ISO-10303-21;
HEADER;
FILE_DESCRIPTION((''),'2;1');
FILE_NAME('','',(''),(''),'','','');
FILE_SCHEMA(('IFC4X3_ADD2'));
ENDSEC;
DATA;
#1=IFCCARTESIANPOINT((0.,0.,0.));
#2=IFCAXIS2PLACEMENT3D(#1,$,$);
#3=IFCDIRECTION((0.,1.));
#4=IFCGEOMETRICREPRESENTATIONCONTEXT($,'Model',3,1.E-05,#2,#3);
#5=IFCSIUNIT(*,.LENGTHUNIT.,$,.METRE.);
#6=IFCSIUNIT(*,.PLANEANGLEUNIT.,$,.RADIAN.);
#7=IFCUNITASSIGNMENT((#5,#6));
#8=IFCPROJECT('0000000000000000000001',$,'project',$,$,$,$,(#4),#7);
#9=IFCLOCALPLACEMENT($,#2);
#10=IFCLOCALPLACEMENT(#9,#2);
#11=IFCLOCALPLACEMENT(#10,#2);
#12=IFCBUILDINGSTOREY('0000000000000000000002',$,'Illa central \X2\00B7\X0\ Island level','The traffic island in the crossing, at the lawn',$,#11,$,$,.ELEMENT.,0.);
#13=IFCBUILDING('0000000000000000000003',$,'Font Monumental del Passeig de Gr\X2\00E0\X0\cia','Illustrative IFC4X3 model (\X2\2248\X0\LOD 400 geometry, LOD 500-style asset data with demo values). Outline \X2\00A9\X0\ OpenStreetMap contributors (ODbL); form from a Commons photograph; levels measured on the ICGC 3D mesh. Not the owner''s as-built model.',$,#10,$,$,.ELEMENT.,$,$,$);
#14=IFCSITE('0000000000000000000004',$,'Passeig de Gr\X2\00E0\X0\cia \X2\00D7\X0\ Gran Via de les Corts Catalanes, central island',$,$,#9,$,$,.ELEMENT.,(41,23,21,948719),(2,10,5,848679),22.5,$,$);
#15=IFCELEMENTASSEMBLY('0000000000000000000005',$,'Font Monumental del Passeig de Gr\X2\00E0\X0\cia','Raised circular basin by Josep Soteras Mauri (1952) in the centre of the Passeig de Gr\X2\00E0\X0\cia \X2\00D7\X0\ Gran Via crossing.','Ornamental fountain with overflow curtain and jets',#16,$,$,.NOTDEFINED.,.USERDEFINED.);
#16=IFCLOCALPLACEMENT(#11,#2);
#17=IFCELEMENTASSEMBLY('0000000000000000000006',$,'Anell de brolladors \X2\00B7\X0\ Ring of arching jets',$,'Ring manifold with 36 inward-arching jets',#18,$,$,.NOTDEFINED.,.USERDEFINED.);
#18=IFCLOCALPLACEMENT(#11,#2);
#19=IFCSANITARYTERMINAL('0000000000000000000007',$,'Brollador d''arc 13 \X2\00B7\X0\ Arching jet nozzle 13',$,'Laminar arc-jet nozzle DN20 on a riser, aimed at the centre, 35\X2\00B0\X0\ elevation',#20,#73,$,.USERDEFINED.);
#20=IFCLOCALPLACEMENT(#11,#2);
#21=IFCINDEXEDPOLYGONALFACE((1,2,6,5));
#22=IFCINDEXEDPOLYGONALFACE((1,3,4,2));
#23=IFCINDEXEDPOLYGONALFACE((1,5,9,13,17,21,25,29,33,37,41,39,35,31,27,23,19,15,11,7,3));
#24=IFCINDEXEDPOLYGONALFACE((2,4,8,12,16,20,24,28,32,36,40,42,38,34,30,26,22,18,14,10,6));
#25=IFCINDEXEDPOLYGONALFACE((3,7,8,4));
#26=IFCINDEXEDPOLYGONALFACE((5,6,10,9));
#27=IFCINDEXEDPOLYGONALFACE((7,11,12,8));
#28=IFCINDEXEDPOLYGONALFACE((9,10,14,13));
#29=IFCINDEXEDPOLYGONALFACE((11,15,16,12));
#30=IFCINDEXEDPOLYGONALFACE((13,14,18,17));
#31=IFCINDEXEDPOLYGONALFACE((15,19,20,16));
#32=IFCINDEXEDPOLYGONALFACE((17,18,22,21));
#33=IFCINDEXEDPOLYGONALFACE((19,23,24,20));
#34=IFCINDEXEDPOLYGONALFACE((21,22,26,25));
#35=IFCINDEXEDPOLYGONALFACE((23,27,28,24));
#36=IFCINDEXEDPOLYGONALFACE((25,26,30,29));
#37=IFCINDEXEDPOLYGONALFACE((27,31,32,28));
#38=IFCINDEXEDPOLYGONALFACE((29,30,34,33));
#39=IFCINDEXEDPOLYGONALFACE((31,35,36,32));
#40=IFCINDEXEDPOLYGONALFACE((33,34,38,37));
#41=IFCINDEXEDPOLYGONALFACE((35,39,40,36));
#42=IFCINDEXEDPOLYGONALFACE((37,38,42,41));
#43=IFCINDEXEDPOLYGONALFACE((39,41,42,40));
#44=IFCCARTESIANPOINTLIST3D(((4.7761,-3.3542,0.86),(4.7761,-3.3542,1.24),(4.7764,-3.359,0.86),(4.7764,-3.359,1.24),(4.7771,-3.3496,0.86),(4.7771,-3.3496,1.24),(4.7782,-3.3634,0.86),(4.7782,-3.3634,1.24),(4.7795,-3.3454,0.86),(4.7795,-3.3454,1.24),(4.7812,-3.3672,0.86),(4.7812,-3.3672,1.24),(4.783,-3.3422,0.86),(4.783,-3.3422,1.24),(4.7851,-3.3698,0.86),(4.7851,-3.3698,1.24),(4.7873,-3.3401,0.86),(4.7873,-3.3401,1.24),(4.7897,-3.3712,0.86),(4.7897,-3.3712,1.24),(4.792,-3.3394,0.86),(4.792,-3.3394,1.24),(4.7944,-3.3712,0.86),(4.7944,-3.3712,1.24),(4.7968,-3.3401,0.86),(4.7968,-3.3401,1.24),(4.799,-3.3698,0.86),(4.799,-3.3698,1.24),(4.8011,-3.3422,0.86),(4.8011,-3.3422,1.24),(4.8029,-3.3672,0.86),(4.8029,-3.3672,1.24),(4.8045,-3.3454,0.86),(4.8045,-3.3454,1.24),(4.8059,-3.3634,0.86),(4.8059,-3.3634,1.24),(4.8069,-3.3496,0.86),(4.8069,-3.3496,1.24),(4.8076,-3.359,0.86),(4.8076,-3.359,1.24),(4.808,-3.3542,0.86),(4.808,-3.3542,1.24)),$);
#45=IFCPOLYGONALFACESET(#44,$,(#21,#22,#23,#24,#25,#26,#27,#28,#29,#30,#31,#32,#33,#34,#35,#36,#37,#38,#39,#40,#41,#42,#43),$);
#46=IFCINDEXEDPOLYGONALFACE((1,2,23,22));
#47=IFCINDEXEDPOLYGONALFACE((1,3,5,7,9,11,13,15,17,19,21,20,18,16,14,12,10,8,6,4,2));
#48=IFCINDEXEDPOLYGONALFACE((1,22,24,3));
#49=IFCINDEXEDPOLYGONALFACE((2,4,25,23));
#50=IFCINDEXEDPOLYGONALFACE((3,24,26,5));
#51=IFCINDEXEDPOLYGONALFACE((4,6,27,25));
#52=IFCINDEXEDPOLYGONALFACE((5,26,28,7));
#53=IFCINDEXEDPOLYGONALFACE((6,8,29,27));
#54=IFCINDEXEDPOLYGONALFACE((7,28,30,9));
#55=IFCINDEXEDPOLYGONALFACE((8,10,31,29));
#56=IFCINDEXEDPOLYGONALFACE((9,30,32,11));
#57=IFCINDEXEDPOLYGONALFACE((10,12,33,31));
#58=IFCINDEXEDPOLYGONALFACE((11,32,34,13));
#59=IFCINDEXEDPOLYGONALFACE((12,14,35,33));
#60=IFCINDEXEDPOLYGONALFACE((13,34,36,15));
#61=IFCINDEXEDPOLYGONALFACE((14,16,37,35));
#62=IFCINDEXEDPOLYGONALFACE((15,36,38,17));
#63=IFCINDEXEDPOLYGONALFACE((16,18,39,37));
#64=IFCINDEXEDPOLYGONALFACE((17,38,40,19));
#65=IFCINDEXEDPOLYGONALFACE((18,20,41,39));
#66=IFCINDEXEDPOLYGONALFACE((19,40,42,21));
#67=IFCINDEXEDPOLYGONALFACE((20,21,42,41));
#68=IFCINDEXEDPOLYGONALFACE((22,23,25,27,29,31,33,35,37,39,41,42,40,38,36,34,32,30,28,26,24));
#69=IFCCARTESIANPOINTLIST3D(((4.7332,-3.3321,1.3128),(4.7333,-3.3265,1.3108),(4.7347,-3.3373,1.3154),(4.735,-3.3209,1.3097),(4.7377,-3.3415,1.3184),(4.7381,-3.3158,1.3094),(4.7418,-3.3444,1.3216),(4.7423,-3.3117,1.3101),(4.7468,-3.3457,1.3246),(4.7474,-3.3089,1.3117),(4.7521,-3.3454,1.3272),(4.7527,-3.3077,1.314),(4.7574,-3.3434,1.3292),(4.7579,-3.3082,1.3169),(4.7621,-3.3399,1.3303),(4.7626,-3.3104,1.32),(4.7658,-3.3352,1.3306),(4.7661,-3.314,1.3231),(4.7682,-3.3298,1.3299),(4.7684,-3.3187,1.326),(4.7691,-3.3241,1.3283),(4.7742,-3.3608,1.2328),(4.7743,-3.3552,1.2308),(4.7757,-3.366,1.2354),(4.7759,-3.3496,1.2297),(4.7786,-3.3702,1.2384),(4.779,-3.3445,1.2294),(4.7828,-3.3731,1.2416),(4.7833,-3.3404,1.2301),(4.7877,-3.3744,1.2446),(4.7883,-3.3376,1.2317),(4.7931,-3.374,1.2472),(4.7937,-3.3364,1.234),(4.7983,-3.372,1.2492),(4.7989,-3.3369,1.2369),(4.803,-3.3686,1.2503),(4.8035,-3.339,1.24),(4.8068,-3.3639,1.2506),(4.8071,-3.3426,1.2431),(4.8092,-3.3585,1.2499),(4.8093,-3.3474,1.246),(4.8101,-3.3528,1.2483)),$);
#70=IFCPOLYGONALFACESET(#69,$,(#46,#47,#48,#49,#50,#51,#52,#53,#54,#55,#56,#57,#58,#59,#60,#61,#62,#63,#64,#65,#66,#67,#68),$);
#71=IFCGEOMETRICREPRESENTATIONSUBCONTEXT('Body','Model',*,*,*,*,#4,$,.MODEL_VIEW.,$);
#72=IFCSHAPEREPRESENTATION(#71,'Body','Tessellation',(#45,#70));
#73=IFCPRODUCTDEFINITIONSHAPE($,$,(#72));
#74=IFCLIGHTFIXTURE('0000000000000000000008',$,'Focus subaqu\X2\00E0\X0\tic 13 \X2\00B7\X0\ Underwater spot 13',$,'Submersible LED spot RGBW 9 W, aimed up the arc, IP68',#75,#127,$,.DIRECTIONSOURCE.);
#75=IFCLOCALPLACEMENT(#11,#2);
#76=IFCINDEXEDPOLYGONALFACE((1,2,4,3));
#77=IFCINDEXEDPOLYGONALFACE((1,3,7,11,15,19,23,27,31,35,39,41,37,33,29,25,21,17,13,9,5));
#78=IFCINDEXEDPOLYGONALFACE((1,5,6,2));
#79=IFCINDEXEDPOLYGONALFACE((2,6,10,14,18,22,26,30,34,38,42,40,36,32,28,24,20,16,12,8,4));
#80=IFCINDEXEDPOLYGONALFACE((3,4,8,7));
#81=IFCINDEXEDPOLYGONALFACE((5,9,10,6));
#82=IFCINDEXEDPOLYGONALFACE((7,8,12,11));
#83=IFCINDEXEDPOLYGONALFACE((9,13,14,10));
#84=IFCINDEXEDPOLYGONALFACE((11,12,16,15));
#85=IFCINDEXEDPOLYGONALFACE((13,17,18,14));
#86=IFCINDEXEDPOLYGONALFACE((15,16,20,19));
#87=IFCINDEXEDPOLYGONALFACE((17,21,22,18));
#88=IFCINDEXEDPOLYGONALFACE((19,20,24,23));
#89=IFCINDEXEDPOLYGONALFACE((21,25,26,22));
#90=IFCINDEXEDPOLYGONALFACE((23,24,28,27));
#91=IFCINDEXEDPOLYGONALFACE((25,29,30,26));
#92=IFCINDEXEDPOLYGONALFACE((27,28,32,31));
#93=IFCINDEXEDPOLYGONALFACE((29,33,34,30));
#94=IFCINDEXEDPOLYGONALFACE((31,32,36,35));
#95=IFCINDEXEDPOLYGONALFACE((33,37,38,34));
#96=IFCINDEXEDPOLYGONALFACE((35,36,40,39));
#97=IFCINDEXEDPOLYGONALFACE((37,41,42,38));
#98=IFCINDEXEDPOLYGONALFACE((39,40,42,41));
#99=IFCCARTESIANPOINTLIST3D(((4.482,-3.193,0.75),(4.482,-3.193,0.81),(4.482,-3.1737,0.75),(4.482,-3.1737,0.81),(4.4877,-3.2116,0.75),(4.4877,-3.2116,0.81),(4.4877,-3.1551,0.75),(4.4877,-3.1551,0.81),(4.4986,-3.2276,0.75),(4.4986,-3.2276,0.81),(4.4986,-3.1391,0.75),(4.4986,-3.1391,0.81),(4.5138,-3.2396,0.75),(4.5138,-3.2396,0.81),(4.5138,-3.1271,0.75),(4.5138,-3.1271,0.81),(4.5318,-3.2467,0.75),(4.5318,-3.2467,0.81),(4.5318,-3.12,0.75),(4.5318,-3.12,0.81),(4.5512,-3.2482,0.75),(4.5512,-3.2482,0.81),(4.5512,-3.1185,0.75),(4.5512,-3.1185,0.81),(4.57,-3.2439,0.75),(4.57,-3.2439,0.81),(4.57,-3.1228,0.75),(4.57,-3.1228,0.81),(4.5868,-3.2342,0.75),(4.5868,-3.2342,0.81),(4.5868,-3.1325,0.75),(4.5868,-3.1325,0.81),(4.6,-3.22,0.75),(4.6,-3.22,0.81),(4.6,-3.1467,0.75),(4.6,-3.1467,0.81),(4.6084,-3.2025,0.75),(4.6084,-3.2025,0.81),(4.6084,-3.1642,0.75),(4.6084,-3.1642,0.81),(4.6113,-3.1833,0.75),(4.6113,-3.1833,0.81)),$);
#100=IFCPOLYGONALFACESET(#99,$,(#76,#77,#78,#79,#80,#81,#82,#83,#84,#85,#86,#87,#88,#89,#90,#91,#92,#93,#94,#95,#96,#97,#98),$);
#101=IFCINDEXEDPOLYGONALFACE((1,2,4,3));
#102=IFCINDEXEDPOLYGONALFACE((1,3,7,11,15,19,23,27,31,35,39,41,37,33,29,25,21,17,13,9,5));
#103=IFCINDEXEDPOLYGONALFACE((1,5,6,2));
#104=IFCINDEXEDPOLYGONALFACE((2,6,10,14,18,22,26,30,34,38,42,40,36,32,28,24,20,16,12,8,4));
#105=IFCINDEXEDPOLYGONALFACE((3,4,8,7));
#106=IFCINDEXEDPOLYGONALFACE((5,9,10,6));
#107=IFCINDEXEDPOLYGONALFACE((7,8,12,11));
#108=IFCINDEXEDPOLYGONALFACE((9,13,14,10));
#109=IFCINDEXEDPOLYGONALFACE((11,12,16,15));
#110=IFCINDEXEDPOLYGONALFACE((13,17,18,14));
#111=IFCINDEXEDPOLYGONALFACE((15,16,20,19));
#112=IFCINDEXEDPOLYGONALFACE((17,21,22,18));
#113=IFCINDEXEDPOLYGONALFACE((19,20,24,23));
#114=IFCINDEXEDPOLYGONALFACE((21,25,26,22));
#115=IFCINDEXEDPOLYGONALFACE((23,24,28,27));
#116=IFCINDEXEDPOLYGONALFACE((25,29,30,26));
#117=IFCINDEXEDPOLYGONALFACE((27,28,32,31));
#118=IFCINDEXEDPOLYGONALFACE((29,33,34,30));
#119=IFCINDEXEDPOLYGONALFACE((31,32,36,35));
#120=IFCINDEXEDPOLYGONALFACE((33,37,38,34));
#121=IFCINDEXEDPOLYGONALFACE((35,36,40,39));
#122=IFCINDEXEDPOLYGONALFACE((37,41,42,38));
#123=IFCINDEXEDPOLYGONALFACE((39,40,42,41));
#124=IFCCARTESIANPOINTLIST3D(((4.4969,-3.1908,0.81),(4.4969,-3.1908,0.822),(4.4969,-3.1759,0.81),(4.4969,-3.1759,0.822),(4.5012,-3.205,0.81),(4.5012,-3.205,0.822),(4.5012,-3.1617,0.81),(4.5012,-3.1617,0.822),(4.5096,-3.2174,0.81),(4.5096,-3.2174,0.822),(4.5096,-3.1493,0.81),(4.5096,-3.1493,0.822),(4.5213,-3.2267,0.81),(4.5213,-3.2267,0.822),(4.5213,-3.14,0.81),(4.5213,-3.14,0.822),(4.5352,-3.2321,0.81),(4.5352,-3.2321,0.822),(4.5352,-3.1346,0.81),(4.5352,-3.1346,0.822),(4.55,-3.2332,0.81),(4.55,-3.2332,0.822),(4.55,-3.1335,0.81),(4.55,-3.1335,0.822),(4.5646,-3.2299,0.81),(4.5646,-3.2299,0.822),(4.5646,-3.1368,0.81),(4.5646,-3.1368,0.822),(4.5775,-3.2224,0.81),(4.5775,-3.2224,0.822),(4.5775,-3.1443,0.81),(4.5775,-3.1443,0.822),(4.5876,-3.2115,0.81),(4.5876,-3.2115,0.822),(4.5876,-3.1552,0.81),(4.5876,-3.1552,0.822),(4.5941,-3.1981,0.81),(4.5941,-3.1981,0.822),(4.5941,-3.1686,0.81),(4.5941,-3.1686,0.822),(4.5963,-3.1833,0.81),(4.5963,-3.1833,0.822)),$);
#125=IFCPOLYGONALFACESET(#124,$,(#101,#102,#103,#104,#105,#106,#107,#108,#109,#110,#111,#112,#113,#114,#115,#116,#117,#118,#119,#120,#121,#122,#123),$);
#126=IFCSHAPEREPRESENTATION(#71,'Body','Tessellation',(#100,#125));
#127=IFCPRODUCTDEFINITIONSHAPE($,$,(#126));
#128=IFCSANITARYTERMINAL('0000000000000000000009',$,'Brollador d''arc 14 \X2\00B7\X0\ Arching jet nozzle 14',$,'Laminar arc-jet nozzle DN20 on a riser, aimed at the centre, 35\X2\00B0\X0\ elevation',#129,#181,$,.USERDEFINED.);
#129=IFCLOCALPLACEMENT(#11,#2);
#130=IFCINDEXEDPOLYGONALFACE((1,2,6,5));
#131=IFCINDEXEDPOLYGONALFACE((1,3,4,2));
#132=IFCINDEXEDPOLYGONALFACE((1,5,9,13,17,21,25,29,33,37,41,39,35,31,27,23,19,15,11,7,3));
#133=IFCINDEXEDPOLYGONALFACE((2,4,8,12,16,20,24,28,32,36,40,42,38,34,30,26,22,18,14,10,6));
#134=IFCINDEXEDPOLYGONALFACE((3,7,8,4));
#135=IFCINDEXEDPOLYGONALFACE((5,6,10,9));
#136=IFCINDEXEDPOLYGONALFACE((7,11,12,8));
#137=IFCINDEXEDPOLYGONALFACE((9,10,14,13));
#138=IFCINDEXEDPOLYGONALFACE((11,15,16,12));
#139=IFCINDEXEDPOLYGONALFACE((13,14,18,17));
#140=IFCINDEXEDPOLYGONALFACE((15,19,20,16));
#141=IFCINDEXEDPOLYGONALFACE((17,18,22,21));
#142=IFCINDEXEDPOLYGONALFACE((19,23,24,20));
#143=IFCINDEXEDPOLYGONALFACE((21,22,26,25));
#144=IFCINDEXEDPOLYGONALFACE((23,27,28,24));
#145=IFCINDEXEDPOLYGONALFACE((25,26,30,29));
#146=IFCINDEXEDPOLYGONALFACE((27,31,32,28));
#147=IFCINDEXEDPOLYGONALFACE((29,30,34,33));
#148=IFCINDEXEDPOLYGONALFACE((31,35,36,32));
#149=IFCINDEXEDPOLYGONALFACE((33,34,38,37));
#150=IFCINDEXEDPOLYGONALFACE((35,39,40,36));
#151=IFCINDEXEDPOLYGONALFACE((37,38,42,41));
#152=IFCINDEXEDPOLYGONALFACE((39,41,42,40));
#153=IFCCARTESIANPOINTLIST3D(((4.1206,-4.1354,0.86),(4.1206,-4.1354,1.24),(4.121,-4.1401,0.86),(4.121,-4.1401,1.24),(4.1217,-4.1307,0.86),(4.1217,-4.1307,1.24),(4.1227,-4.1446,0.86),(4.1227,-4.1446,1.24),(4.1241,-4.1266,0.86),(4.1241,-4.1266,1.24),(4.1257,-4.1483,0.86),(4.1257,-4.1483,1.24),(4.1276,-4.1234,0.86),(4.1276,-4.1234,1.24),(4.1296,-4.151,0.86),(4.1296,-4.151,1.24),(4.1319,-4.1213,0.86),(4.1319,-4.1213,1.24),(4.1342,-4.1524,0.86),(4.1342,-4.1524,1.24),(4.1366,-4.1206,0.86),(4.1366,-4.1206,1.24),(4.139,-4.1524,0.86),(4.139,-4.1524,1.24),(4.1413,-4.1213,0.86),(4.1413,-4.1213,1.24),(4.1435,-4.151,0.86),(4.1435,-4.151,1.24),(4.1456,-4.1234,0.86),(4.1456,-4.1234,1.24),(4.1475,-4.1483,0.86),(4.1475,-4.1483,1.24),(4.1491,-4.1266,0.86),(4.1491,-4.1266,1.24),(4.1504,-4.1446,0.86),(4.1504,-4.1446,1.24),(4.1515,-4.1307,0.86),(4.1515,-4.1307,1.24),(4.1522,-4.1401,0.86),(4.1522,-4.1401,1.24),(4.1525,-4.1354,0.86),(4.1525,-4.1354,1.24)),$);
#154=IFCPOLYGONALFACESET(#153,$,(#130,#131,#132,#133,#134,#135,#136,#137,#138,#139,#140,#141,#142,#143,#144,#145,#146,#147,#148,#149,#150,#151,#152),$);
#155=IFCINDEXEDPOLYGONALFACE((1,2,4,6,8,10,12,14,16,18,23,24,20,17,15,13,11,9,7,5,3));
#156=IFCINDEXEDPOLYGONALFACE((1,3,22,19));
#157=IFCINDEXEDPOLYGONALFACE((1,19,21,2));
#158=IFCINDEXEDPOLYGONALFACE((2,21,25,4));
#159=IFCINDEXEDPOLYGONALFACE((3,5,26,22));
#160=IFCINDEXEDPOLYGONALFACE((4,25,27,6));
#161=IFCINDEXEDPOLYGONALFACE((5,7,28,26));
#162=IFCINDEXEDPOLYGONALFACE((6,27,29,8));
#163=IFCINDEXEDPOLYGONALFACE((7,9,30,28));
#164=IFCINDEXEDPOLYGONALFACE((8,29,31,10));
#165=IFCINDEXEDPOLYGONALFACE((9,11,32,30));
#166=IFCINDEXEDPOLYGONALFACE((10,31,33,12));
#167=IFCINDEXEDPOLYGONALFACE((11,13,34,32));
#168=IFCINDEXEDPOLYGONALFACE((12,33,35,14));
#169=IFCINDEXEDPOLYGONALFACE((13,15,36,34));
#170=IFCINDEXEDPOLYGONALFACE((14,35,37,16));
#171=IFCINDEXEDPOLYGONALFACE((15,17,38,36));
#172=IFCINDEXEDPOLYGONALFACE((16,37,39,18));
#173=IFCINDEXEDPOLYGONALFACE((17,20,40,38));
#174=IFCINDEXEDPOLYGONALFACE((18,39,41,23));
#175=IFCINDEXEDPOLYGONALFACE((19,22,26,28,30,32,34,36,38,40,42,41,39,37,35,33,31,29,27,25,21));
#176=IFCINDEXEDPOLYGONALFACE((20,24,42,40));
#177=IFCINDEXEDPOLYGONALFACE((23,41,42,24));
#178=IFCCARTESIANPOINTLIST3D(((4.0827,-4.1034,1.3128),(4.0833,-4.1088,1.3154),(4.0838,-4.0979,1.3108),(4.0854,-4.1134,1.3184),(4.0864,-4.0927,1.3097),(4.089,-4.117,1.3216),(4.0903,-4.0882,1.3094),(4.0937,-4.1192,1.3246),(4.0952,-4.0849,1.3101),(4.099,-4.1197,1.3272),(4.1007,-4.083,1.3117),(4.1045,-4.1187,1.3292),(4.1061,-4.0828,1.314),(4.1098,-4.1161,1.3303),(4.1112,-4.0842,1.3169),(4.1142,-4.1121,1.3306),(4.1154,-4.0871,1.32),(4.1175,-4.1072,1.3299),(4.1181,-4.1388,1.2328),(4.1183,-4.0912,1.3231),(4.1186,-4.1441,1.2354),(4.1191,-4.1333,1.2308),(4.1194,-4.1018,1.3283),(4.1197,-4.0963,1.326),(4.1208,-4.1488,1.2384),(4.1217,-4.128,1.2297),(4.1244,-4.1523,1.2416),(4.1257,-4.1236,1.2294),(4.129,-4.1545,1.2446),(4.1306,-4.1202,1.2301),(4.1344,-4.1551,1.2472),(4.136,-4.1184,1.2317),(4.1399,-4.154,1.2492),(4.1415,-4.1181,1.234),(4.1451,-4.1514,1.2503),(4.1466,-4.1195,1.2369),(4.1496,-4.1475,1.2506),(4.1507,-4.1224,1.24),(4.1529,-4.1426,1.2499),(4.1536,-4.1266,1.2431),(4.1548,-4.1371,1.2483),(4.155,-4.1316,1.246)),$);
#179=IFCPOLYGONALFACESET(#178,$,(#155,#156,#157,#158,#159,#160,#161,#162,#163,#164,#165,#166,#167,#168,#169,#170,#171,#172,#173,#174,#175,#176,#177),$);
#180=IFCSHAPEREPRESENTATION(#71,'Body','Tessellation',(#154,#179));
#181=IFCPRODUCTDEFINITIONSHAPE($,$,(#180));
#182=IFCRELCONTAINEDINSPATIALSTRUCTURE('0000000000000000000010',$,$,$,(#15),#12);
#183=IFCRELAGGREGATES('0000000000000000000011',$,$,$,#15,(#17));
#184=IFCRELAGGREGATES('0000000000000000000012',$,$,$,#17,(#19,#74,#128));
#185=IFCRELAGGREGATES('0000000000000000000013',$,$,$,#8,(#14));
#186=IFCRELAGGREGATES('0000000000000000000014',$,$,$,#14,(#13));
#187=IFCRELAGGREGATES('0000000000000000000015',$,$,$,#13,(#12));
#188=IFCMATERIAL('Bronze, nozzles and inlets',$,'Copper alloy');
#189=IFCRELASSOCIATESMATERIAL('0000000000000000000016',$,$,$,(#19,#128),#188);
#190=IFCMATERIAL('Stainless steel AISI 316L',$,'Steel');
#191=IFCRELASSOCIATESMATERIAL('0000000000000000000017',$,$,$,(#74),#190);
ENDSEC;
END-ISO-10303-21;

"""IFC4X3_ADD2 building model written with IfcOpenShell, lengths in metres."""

from ifc_helpers import new_model, si_unit, direction, frame, origin, origin_2d_with_axis, place, context, subcontext, project, spatial, circle, extrude, material, element, aggregate, save


model = new_model("IFC4X3_ADD2")

# Units and contexts
model_context = context("Model", 3, precision=1e-05, world=origin(), true_north=direction((0.0, 1.0)))
body_context = subcontext(model_context, "Body", "Model", "MODEL_VIEW")
ifc_project = project(units=[si_unit("LENGTHUNIT", "METRE"), si_unit("PLANEANGLEUNIT", "RADIAN")], contexts=[model_context])

# Site, building, storey
site_placement = place(None, origin())
site = spatial("IfcSite", under=ifc_project, at=site_placement, Name="Passeig de Gràcia × Gran Via de les Corts Catalanes, central island", CompositionType="ELEMENT", RefLatitude=(41, 23, 21, 948719), RefLongitude=(2, 10, 5, 848679), RefElevation=22.5)
building_placement = place(site_placement, origin())
building = spatial("IfcBuilding", under=site, at=building_placement, Name="Font Monumental del Passeig de Gràcia", Description="Illustrative IFC4X3 model (≈LOD 400 geometry, LOD 500-style asset data with demo values). Outline © OpenStreetMap contributors (ODbL); form from a Commons photograph; levels measured on the ICGC 3D mesh. Not the owner's as-built model.", CompositionType="ELEMENT")
storey_placement = place(building_placement, origin())
storey = spatial("IfcBuildingStorey", under=building, at=storey_placement, Name="Illa central · Island level", Description="The traffic island in the crossing, at the lawn", CompositionType="ELEMENT", Elevation=0.0)

# Element assemblies, sanitary terminals, light fixture
assembly_1_placement = place(building_placement, origin())
assembly_1 = element("IfcElementAssembly", 1, at=assembly_1_placement, inside=storey, Name="Font Monumental del Passeig de Gràcia", Description="Raised circular basin by Josep Soteras Mauri (1952) in the centre of the Passeig de Gràcia × Gran Via crossing.", ObjectType="Ornamental fountain with overflow curtain and jets", AssemblyPlace="NOTDEFINED", PredefinedType="USERDEFINED")
assembly_2_placement = place(building_placement, origin())
assembly_2 = element("IfcElementAssembly", 2, at=assembly_2_placement, Name="Anell de brolladors · Ring of arching jets", ObjectType="Ring manifold with 36 inward-arching jets", AssemblyPlace="NOTDEFINED", PredefinedType="USERDEFINED")
aggregate(assembly_1, [assembly_2])
ifc_material_1 = material(Name="Bronze, nozzles and inlets", Category="Copper alloy")
ifc_material_2 = material(Name="Stainless steel AISI 316L", Category="Steel")
sanitary_terminal_1_placement = place(building_placement, origin())
sanitary_terminal_1 = element("IfcSanitaryTerminal", 3, at=sanitary_terminal_1_placement, material=ifc_material_1, Name="Brollador d'arc 13 · Arching jet nozzle 13", ObjectType="Laminar arc-jet nozzle DN20 on a riser, aimed at the centre, 35° elevation", PredefinedType="USERDEFINED", context=body_context, shape_type="SweptSolid", body=[
    extrude(circle(Radius=0.016, at=origin_2d_with_axis()), frame((4.792, -3.3554, 0.86), z_axis=(0.0, 0.0, 1.0), x_axis=(0.0, 1.0, 0.0)), (0.0, 0.0, 1.0), 0.38),
    extrude(circle(Radius=0.02, at=origin_2d_with_axis()), frame((4.792, -3.3554, 1.24), z_axis=(-0.43415, 0.303995, 0.847998), x_axis=(0.573576, 0.819152, 0.0)), (0.0, 0.0, 1.0), 0.0943),
])
light_fixture_1_placement = place(building_placement, origin())
light_fixture_1 = element("IfcLightFixture", 4, at=light_fixture_1_placement, material=ifc_material_2, Name="Focus subaquàtic 13 · Underwater spot 13", ObjectType="Submersible LED spot RGBW 9 W, aimed up the arc, IP68", PredefinedType="DIRECTIONSOURCE", context=body_context, shape_type="SweptSolid", body=[
    extrude(circle(Radius=0.065, at=origin_2d_with_axis()), frame((4.5463, -3.1833, 0.75)), (0.0, 0.0, 1.0), 0.06),
    extrude(circle(Radius=0.05, at=origin_2d_with_axis()), frame((4.5463, -3.1833, 0.81)), (0.0, 0.0, 1.0), 0.012),
])
sanitary_terminal_2_placement = place(building_placement, origin())
sanitary_terminal_2 = element("IfcSanitaryTerminal", 5, at=sanitary_terminal_2_placement, material=ifc_material_1, Name="Brollador d'arc 14 · Arching jet nozzle 14", ObjectType="Laminar arc-jet nozzle DN20 on a riser, aimed at the centre, 35° elevation", PredefinedType="USERDEFINED", context=body_context, shape_type="SweptSolid", body=[
    extrude(circle(Radius=0.016, at=origin_2d_with_axis()), frame((4.1366, -4.1366, 0.86), z_axis=(0.0, 0.0, 1.0), x_axis=(0.0, 1.0, 0.0)), (0.0, 0.0, 1.0), 0.38),
    extrude(circle(Radius=0.02, at=origin_2d_with_axis()), frame((4.1366, -4.1366, 1.24), z_axis=(-0.374766, 0.374766, 0.847998), x_axis=(0.707107, 0.707107, 0.0)), (0.0, 0.0, 1.0), 0.0943),
])
aggregate(assembly_2, [sanitary_terminal_1, light_fixture_1, sanitary_terminal_2])

save(model, "model.ifc")
